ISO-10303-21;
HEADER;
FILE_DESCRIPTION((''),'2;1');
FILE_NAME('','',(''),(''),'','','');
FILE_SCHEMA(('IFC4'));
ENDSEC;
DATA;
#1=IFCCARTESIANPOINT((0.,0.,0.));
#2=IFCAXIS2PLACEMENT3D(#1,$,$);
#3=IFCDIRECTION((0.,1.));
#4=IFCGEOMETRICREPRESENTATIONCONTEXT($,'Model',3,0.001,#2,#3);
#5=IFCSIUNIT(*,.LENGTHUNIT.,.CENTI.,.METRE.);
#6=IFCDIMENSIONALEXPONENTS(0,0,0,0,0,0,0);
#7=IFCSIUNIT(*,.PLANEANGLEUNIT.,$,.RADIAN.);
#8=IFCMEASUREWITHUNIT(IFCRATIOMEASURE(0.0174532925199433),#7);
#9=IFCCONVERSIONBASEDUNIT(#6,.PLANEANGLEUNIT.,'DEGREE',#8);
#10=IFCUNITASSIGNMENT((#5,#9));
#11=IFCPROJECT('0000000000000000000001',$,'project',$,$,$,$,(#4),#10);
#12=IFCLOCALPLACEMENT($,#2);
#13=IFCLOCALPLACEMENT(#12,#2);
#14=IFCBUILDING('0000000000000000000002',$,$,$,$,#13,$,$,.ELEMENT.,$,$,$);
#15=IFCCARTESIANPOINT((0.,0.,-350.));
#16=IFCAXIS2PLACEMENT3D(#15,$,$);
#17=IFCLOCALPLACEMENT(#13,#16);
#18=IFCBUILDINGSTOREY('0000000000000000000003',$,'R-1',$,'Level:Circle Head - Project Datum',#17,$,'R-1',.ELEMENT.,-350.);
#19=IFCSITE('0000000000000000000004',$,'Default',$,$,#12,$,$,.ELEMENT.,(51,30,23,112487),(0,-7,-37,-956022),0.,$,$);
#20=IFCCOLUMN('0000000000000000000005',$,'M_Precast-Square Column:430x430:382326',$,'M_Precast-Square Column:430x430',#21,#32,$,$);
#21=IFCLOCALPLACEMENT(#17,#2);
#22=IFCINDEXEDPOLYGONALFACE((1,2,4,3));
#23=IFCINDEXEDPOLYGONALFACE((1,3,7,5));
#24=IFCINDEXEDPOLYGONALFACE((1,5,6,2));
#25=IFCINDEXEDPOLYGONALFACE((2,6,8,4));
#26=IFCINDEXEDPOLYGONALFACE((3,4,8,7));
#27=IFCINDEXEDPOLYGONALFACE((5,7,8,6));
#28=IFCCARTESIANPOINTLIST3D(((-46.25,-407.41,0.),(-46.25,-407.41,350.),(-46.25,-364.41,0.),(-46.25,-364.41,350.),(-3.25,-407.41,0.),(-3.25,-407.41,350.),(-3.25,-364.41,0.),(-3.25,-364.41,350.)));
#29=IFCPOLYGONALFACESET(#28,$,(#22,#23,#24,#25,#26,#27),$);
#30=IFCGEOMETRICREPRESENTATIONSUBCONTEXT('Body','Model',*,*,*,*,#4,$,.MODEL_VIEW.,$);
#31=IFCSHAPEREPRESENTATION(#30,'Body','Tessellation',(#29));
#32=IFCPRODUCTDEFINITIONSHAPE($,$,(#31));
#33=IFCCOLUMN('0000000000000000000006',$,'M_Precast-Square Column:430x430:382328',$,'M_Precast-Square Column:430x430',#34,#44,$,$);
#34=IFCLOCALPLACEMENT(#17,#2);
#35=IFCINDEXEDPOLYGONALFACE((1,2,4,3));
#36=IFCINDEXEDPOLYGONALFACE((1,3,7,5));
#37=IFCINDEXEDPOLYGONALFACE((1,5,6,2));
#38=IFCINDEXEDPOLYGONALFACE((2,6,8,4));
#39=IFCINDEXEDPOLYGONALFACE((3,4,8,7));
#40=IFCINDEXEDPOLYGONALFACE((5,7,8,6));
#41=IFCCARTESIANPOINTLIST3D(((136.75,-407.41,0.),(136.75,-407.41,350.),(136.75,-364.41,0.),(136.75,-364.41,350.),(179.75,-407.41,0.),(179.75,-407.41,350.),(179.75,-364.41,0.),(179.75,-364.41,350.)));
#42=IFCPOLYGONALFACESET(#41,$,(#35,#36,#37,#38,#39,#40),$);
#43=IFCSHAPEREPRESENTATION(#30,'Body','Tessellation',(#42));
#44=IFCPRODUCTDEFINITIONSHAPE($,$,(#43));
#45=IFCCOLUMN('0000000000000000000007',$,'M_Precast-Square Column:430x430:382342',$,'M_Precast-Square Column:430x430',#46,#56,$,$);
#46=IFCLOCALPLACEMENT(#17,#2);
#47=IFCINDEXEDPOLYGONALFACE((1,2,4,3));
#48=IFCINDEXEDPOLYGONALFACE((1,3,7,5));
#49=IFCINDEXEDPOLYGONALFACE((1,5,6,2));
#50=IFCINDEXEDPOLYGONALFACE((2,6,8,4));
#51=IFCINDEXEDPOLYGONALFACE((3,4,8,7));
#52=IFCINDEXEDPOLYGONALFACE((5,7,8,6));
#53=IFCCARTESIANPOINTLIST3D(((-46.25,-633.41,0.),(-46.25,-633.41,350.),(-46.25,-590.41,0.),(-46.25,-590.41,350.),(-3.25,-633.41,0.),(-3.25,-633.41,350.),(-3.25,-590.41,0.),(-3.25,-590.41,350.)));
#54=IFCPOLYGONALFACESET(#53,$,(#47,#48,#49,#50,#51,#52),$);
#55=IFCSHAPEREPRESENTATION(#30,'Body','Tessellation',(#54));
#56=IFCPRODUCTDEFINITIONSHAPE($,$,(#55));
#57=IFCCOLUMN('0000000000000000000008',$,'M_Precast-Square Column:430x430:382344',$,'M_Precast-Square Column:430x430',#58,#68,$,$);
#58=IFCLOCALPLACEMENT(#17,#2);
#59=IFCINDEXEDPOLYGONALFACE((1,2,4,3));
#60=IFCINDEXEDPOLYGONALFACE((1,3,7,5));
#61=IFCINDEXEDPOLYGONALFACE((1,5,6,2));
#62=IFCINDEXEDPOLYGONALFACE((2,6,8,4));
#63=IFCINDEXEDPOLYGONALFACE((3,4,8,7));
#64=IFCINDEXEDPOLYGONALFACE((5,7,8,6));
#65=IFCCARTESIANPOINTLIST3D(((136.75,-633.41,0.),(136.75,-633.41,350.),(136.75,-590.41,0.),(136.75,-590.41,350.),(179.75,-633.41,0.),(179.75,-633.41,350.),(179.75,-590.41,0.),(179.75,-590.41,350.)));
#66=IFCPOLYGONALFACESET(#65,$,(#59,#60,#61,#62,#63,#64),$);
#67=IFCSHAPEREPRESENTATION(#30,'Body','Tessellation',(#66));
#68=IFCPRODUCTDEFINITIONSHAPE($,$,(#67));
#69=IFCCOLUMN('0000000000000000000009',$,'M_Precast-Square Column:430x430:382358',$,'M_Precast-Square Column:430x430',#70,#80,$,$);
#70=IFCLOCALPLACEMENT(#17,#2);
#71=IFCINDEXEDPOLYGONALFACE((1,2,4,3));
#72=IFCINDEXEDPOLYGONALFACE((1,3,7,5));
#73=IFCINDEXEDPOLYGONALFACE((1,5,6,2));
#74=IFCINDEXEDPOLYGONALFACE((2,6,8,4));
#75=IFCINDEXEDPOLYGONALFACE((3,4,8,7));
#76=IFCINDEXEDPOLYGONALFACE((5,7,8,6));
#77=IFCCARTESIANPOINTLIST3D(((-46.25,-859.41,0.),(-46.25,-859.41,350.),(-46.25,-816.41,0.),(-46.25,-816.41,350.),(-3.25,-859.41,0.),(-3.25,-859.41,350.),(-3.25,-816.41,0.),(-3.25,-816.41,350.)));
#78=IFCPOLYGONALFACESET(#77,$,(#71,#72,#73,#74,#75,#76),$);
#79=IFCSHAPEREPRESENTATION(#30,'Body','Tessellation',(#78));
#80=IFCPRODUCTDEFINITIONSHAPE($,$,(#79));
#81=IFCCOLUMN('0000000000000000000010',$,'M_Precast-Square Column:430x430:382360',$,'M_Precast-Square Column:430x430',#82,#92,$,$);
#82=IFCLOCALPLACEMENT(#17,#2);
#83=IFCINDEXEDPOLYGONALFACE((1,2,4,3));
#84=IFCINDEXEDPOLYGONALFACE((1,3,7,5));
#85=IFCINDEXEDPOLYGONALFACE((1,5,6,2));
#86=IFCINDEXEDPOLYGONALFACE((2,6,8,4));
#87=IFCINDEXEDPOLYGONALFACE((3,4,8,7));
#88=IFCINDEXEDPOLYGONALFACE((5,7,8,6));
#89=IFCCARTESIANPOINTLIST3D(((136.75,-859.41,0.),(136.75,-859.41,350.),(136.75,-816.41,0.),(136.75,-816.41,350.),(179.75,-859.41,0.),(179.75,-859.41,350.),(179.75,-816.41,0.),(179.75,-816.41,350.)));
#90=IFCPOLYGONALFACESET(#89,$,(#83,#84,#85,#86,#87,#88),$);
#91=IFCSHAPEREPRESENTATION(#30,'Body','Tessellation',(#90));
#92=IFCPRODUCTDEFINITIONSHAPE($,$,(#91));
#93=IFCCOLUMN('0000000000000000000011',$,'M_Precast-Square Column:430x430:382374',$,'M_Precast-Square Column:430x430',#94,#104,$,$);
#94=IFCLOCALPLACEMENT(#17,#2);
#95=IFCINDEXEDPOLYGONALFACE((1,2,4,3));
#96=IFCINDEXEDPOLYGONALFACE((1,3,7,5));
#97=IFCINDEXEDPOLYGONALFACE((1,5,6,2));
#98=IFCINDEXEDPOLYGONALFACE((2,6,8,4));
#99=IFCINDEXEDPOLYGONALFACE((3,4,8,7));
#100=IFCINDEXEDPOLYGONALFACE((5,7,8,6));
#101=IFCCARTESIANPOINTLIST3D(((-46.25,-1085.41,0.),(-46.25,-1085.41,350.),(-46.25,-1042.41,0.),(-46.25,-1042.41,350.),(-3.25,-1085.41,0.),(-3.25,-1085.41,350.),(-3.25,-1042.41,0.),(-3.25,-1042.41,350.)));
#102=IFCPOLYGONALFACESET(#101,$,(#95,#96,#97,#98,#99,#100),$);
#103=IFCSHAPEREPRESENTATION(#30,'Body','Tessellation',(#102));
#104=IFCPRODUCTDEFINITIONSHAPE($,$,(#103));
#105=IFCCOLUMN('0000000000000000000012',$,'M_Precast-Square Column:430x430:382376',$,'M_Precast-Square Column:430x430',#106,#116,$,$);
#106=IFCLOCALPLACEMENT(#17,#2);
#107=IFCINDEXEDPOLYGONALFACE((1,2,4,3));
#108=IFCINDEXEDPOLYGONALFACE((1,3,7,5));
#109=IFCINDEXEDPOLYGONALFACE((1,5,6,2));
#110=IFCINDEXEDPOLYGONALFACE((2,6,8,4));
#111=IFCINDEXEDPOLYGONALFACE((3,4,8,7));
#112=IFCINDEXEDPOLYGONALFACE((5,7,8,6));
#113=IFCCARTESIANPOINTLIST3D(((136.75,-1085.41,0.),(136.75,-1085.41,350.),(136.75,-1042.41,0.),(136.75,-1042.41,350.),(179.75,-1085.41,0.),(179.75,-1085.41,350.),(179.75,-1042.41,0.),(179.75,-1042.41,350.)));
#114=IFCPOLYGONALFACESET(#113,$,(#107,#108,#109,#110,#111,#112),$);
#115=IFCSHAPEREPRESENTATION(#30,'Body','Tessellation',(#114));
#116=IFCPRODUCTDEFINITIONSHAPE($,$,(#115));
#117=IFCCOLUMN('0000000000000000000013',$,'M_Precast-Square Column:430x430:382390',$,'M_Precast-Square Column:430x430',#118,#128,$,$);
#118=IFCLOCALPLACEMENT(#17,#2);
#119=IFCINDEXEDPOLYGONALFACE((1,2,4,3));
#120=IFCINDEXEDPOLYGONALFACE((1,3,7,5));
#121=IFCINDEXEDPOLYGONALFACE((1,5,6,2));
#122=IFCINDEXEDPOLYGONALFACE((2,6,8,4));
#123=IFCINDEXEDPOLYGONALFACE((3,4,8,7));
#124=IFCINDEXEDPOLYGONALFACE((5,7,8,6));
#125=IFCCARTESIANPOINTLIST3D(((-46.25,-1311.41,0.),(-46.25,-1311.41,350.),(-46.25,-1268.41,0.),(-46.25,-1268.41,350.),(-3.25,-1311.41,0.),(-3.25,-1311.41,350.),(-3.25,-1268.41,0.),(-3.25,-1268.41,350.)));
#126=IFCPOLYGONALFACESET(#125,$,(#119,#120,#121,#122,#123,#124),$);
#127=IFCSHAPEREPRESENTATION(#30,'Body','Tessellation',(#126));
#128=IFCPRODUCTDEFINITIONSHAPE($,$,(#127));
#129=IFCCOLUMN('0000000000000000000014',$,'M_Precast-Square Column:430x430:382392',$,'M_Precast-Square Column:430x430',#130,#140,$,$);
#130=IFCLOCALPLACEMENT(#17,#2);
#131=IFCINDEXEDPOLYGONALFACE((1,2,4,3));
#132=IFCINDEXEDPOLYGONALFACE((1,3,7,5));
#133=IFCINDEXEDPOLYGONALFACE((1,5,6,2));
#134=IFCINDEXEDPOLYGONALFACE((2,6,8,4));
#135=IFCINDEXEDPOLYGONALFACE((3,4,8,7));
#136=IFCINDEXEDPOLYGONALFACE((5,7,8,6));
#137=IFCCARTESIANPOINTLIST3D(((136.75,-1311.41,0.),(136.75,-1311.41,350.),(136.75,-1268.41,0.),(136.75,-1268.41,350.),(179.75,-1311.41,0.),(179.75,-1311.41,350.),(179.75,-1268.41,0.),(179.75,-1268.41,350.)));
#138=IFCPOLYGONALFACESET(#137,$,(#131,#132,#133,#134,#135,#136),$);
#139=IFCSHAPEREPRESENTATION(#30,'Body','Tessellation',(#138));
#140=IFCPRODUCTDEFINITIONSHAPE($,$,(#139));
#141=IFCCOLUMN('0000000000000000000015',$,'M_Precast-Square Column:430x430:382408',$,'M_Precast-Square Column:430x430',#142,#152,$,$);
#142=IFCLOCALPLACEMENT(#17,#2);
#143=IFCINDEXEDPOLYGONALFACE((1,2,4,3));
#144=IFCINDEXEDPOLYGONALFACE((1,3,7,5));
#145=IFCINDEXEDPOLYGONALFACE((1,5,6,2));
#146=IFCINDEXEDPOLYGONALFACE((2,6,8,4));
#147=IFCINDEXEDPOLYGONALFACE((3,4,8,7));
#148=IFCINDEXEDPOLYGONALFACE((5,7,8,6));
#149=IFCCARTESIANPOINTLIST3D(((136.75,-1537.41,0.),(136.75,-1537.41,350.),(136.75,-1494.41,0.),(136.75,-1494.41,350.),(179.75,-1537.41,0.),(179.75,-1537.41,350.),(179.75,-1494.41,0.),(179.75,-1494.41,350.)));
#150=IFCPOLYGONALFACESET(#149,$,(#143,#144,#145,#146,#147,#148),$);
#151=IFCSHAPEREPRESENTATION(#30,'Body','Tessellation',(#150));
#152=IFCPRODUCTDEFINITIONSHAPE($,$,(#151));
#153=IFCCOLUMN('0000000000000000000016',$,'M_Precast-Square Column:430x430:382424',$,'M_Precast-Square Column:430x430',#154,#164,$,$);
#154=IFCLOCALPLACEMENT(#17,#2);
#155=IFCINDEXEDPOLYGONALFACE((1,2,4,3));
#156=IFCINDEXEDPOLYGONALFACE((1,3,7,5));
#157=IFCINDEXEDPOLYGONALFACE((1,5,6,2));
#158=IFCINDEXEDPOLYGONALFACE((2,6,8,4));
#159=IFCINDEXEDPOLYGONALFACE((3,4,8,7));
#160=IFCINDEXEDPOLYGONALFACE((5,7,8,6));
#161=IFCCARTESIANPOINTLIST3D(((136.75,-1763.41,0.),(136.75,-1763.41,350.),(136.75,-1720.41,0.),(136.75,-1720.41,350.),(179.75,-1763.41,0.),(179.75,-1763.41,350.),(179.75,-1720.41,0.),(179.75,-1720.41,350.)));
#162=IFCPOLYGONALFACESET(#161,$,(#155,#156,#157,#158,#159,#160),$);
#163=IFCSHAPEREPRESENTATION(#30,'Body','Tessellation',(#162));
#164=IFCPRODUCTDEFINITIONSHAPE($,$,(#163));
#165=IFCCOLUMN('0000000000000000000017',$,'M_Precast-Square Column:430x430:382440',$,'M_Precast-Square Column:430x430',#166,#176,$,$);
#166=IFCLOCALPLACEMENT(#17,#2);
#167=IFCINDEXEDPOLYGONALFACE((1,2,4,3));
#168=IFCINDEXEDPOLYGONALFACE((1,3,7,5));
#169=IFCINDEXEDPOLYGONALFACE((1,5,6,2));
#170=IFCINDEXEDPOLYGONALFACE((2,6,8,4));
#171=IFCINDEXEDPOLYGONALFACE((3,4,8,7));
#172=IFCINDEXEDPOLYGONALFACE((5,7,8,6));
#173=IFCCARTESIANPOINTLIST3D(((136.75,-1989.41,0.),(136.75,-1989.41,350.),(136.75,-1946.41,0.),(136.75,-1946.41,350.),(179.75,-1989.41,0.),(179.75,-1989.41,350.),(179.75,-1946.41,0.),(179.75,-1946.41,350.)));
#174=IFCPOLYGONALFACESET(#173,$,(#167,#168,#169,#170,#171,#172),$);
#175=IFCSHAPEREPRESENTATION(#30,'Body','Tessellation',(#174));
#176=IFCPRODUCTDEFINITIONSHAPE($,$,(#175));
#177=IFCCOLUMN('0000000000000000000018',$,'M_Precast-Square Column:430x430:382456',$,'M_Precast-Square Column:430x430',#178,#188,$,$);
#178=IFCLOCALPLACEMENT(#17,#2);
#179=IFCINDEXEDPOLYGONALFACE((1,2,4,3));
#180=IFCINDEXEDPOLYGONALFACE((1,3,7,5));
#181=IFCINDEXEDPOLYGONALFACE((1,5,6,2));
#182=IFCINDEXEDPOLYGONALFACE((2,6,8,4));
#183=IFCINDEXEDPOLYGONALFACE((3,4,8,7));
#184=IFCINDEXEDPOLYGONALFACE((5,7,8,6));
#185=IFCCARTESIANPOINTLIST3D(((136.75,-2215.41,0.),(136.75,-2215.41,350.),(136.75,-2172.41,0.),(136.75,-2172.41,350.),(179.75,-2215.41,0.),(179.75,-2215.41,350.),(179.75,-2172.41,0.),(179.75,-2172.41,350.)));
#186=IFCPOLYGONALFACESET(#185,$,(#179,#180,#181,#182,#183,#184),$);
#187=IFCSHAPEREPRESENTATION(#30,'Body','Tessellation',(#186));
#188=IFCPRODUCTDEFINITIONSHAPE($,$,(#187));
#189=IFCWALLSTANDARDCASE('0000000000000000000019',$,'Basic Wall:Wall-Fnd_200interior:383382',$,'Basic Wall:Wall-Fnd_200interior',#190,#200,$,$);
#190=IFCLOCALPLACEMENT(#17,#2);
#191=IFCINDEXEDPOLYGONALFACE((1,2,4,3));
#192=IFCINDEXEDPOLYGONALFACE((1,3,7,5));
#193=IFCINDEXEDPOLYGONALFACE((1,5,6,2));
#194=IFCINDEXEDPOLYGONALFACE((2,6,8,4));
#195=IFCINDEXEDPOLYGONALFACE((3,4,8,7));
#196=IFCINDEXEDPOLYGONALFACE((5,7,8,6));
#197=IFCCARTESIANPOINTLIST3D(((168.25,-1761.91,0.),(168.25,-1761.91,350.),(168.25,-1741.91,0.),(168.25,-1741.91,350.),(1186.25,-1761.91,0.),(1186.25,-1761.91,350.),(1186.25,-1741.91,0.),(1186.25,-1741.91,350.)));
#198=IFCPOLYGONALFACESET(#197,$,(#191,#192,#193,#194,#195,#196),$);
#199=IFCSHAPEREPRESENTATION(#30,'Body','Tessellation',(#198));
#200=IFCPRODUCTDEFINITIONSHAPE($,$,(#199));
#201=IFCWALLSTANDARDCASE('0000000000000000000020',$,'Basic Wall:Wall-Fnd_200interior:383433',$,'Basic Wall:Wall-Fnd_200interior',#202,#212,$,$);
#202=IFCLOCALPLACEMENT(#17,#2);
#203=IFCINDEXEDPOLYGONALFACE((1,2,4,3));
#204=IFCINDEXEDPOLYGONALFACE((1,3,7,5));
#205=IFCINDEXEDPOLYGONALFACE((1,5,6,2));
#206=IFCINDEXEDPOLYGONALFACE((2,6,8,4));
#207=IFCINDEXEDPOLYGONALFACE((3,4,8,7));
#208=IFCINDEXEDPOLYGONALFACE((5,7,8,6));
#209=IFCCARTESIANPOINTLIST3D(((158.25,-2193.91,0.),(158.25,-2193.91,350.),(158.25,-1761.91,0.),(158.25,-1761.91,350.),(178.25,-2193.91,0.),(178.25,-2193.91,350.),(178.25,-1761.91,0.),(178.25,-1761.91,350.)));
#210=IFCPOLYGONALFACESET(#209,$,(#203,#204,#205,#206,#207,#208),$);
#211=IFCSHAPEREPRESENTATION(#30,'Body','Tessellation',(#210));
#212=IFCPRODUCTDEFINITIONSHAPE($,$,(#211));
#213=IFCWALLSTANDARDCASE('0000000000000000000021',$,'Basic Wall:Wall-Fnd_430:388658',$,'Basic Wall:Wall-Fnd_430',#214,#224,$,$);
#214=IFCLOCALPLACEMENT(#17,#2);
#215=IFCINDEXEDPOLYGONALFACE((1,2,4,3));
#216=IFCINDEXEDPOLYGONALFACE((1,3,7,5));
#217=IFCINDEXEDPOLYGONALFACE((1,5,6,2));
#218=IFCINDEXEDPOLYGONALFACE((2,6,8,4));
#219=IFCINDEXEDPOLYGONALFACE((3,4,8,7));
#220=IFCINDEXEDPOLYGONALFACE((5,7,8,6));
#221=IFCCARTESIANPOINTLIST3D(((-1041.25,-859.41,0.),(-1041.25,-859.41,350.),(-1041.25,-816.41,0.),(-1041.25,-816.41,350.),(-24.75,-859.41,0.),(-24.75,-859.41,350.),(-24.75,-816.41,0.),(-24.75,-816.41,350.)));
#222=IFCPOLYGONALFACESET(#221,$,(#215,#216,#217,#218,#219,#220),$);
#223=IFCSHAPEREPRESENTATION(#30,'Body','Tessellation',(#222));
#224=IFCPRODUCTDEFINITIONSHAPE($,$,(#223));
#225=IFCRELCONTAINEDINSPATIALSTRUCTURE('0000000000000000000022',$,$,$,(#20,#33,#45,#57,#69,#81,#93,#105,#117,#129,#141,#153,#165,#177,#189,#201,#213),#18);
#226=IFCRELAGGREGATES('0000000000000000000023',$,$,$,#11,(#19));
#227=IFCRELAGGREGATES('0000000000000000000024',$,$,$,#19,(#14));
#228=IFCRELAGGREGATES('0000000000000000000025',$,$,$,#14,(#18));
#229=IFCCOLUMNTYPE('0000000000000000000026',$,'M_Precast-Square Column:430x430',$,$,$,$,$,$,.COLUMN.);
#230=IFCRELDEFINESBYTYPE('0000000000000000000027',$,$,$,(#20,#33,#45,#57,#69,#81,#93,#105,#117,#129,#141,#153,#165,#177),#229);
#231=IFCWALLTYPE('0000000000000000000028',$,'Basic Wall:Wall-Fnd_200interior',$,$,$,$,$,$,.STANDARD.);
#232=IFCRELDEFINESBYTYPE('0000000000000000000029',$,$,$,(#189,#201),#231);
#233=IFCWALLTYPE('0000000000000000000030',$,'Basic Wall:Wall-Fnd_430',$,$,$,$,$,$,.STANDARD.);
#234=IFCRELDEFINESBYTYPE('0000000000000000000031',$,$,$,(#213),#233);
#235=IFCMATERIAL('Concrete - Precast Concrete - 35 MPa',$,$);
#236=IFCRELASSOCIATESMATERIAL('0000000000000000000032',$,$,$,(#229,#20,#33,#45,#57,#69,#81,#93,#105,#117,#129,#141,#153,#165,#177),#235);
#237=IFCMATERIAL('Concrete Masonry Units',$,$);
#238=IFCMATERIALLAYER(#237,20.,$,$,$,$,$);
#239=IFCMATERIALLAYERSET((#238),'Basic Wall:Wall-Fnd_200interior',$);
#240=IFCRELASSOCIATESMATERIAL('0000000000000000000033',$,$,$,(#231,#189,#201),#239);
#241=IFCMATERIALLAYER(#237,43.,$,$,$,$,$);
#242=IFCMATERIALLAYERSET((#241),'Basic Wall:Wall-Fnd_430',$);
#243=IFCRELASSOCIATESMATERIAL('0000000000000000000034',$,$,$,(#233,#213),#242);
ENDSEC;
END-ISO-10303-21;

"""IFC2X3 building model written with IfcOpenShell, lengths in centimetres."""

from ifc_helpers import new_model, entity, si_unit, converted_unit, direction, frame, frame_2d, origin, origin_2d_with_axis, place, context, subcontext, project, spatial, rectangle, extrude, source, transform, mapped, material, layer, layer_set, layer_usage, type_object, type_shapes, element, save


model = new_model("IFC2X3")

# Units and contexts
model_context = context("Model", 3, precision=0.001, world=origin(), true_north=direction((0.0, 1.0)))
body_context = subcontext(model_context, "Body", "Model", "MODEL_VIEW")
ifc_project = project(units=[si_unit("LENGTHUNIT", "METRE", prefix="CENTI"), converted_unit("PLANEANGLEUNIT", "DEGREE", entity("IfcRatioMeasure", 0.0174532925199433), si_unit("PLANEANGLEUNIT", "RADIAN"), dimensions=[0, 0, 0, 0, 0, 0, 0])], contexts=[model_context])

# Site, building, storey
site_placement = place(None, origin())
site = spatial("IfcSite", under=ifc_project, at=site_placement, Name="Default", CompositionType="ELEMENT", RefLatitude=(51, 30, 23, 112487), RefLongitude=(0, -7, -37, -956022), RefElevation=0.0)
building_placement = place(site_placement, origin())
building = spatial("IfcBuilding", under=site, at=building_placement, CompositionType="ELEMENT")
storey_placement = place(building_placement, frame((0.0, 0.0, -350.0)))
storey = spatial("IfcBuildingStorey", under=building, at=storey_placement, Name="R-1", ObjectType="Level:Circle Head - Project Datum", LongName="R-1", CompositionType="ELEMENT", Elevation=-350.0)

# Columns
ifc_material_1 = material(Name="Concrete - Precast Concrete - 35 MPa")
column_type = type_object("IfcColumnType", Name="M_Precast-Square Column:430x430", PredefinedType="COLUMN", material=ifc_material_1)
shared_shape = source(origin(), body_context, "Body", "SweptSolid", [
    extrude(rectangle(XDim=43.0, YDim=43.0, at=origin_2d_with_axis()), frame((0.0, 0.0, -350.0), z_axis=(0.0, 0.0, 1.0), x_axis=(0.0, -1.0, 0.0)), (0.0, 0.0, 1.0), 350.0),
])
type_shapes(column_type, [shared_shape])
for number, where, z_axis, x_axis, name in (
    (1, (-24.75, -385.91, 350.0), (0.0, 0.0, 1.0), (-1.0, 0.0, 0.0), "M_Precast-Square Column:430x430:382326"),
    (2, (158.25, -385.91, 350.0), (0.0, 0.0, 1.0), (-1.0, 0.0, 0.0), "M_Precast-Square Column:430x430:382328"),
    (3, (-24.75, -611.91, 350.0), (0.0, 0.0, 1.0), (-1.0, 0.0, 0.0), "M_Precast-Square Column:430x430:382342"),
    (4, (158.25, -611.91, 350.0), (0.0, 0.0, 1.0), (-1.0, 0.0, 0.0), "M_Precast-Square Column:430x430:382344"),
    (5, (-24.75, -837.91, 350.0), (0.0, 0.0, 1.0), (-1.0, 0.0, 0.0), "M_Precast-Square Column:430x430:382358"),
    (6, (158.25, -837.91, 350.0), (0.0, 0.0, 1.0), (-1.0, 0.0, 0.0), "M_Precast-Square Column:430x430:382360"),
    (7, (-24.75, -1063.91, 350.0), (0.0, 0.0, 1.0), (-1.0, 0.0, 0.0), "M_Precast-Square Column:430x430:382374"),
    (8, (158.25, -1063.91, 350.0), (0.0, 0.0, 1.0), (-1.0, 0.0, 0.0), "M_Precast-Square Column:430x430:382376"),
    (9, (-24.75, -1289.91, 350.0), (0.0, 0.0, 1.0), (-1.0, 0.0, 0.0), "M_Precast-Square Column:430x430:382390"),
    (10, (158.25, -1289.91, 350.0), (0.0, 0.0, 1.0), (-1.0, 0.0, 0.0), "M_Precast-Square Column:430x430:382392"),
    (11, (158.25, -1515.91, 350.0), (0.0, 0.0, 1.0), (-1.0, 0.0, 0.0), "M_Precast-Square Column:430x430:382408"),
    (12, (158.25, -1741.91, 350.0), (0.0, 0.0, 1.0), (-1.0, 0.0, 0.0), "M_Precast-Square Column:430x430:382424"),
    (13, (158.25, -1967.91, 350.0), (0.0, 0.0, 1.0), (-1.0, 0.0, 0.0), "M_Precast-Square Column:430x430:382440"),
    (14, (158.25, -2193.91, 350.0), (0.0, 0.0, 1.0), (-1.0, 0.0, 0.0), "M_Precast-Square Column:430x430:382456"),
):
    element("IfcColumn", number, at=place(storey_placement, frame(where, z_axis=z_axis, x_axis=x_axis)), inside=storey, type_object=column_type, material=ifc_material_1, Name=name, ObjectType="M_Precast-Square Column:430x430", context=body_context, shape_type="MappedRepresentation", body=[
        mapped(shared_shape, transform((0.0, 0.0, 0.0), scale=1.0)),
    ])

# Walls
ifc_material_2 = material(Name="Concrete Masonry Units")
ifc_layer_1 = layer(ifc_material_2, 20.0)
ifc_layer_set_1 = layer_set([ifc_layer_1], Name="Basic Wall:Wall-Fnd_200interior")
ifc_layer_usage_1 = layer_usage(ifc_layer_set_1, "AXIS2", "NEGATIVE", 10.0)
wall_type_1 = type_object("IfcWallType", Name="Basic Wall:Wall-Fnd_200interior", PredefinedType="STANDARD", material=ifc_layer_set_1)
wall_1_placement = place(storey_placement, frame((168.25, -1751.91, 0.0)))
element("IfcWallStandardCase", 15, at=wall_1_placement, inside=storey, type_object=wall_type_1, material=ifc_layer_usage_1, Name="Basic Wall:Wall-Fnd_200interior:383382", ObjectType="Basic Wall:Wall-Fnd_200interior", context=body_context, shape_type="SweptSolid", body=[
    extrude(rectangle(XDim=1018.0, YDim=20.0, at=frame_2d((509.0, 0.0), x_axis=(-1.0, 0.0))), origin(), (0.0, 0.0, 1.0), 350.0),
])
ifc_layer_usage_2 = layer_usage(ifc_layer_set_1, "AXIS2", "NEGATIVE", 10.0)
wall_2_placement = place(storey_placement, frame((168.25, -2193.91, 0.0), z_axis=(0.0, 0.0, 1.0), x_axis=(0.0, 1.0, 0.0)))
element("IfcWallStandardCase", 16, at=wall_2_placement, inside=storey, type_object=wall_type_1, material=ifc_layer_usage_2, Name="Basic Wall:Wall-Fnd_200interior:383433", ObjectType="Basic Wall:Wall-Fnd_200interior", context=body_context, shape_type="SweptSolid", body=[
    extrude(rectangle(XDim=432.0, YDim=20.0, at=frame_2d((216.0, 0.0), x_axis=(-1.0, 0.0))), origin(), (0.0, 0.0, 1.0), 350.0),
])
ifc_layer_2 = layer(ifc_material_2, 43.0)
ifc_layer_set_2 = layer_set([ifc_layer_2], Name="Basic Wall:Wall-Fnd_430")
ifc_layer_usage_3 = layer_usage(ifc_layer_set_2, "AXIS2", "NEGATIVE", 21.5)
wall_type_2 = type_object("IfcWallType", Name="Basic Wall:Wall-Fnd_430", PredefinedType="STANDARD", material=ifc_layer_set_2)
wall_3_placement = place(storey_placement, frame((-24.75, -837.91, 0.0), z_axis=(0.0, 0.0, 1.0), x_axis=(-1.0, 0.0, 0.0)))
element("IfcWallStandardCase", 17, at=wall_3_placement, inside=storey, type_object=wall_type_2, material=ifc_layer_usage_3, Name="Basic Wall:Wall-Fnd_430:388658", ObjectType="Basic Wall:Wall-Fnd_430", context=body_context, shape_type="SweptSolid", body=[
    extrude(rectangle(XDim=1016.5, YDim=43.0, at=frame_2d((508.25, 0.0), x_axis=(-1.0, 0.0))), origin(), (0.0, 0.0, 1.0), 350.0),
])

save(model, "model.ifc")
